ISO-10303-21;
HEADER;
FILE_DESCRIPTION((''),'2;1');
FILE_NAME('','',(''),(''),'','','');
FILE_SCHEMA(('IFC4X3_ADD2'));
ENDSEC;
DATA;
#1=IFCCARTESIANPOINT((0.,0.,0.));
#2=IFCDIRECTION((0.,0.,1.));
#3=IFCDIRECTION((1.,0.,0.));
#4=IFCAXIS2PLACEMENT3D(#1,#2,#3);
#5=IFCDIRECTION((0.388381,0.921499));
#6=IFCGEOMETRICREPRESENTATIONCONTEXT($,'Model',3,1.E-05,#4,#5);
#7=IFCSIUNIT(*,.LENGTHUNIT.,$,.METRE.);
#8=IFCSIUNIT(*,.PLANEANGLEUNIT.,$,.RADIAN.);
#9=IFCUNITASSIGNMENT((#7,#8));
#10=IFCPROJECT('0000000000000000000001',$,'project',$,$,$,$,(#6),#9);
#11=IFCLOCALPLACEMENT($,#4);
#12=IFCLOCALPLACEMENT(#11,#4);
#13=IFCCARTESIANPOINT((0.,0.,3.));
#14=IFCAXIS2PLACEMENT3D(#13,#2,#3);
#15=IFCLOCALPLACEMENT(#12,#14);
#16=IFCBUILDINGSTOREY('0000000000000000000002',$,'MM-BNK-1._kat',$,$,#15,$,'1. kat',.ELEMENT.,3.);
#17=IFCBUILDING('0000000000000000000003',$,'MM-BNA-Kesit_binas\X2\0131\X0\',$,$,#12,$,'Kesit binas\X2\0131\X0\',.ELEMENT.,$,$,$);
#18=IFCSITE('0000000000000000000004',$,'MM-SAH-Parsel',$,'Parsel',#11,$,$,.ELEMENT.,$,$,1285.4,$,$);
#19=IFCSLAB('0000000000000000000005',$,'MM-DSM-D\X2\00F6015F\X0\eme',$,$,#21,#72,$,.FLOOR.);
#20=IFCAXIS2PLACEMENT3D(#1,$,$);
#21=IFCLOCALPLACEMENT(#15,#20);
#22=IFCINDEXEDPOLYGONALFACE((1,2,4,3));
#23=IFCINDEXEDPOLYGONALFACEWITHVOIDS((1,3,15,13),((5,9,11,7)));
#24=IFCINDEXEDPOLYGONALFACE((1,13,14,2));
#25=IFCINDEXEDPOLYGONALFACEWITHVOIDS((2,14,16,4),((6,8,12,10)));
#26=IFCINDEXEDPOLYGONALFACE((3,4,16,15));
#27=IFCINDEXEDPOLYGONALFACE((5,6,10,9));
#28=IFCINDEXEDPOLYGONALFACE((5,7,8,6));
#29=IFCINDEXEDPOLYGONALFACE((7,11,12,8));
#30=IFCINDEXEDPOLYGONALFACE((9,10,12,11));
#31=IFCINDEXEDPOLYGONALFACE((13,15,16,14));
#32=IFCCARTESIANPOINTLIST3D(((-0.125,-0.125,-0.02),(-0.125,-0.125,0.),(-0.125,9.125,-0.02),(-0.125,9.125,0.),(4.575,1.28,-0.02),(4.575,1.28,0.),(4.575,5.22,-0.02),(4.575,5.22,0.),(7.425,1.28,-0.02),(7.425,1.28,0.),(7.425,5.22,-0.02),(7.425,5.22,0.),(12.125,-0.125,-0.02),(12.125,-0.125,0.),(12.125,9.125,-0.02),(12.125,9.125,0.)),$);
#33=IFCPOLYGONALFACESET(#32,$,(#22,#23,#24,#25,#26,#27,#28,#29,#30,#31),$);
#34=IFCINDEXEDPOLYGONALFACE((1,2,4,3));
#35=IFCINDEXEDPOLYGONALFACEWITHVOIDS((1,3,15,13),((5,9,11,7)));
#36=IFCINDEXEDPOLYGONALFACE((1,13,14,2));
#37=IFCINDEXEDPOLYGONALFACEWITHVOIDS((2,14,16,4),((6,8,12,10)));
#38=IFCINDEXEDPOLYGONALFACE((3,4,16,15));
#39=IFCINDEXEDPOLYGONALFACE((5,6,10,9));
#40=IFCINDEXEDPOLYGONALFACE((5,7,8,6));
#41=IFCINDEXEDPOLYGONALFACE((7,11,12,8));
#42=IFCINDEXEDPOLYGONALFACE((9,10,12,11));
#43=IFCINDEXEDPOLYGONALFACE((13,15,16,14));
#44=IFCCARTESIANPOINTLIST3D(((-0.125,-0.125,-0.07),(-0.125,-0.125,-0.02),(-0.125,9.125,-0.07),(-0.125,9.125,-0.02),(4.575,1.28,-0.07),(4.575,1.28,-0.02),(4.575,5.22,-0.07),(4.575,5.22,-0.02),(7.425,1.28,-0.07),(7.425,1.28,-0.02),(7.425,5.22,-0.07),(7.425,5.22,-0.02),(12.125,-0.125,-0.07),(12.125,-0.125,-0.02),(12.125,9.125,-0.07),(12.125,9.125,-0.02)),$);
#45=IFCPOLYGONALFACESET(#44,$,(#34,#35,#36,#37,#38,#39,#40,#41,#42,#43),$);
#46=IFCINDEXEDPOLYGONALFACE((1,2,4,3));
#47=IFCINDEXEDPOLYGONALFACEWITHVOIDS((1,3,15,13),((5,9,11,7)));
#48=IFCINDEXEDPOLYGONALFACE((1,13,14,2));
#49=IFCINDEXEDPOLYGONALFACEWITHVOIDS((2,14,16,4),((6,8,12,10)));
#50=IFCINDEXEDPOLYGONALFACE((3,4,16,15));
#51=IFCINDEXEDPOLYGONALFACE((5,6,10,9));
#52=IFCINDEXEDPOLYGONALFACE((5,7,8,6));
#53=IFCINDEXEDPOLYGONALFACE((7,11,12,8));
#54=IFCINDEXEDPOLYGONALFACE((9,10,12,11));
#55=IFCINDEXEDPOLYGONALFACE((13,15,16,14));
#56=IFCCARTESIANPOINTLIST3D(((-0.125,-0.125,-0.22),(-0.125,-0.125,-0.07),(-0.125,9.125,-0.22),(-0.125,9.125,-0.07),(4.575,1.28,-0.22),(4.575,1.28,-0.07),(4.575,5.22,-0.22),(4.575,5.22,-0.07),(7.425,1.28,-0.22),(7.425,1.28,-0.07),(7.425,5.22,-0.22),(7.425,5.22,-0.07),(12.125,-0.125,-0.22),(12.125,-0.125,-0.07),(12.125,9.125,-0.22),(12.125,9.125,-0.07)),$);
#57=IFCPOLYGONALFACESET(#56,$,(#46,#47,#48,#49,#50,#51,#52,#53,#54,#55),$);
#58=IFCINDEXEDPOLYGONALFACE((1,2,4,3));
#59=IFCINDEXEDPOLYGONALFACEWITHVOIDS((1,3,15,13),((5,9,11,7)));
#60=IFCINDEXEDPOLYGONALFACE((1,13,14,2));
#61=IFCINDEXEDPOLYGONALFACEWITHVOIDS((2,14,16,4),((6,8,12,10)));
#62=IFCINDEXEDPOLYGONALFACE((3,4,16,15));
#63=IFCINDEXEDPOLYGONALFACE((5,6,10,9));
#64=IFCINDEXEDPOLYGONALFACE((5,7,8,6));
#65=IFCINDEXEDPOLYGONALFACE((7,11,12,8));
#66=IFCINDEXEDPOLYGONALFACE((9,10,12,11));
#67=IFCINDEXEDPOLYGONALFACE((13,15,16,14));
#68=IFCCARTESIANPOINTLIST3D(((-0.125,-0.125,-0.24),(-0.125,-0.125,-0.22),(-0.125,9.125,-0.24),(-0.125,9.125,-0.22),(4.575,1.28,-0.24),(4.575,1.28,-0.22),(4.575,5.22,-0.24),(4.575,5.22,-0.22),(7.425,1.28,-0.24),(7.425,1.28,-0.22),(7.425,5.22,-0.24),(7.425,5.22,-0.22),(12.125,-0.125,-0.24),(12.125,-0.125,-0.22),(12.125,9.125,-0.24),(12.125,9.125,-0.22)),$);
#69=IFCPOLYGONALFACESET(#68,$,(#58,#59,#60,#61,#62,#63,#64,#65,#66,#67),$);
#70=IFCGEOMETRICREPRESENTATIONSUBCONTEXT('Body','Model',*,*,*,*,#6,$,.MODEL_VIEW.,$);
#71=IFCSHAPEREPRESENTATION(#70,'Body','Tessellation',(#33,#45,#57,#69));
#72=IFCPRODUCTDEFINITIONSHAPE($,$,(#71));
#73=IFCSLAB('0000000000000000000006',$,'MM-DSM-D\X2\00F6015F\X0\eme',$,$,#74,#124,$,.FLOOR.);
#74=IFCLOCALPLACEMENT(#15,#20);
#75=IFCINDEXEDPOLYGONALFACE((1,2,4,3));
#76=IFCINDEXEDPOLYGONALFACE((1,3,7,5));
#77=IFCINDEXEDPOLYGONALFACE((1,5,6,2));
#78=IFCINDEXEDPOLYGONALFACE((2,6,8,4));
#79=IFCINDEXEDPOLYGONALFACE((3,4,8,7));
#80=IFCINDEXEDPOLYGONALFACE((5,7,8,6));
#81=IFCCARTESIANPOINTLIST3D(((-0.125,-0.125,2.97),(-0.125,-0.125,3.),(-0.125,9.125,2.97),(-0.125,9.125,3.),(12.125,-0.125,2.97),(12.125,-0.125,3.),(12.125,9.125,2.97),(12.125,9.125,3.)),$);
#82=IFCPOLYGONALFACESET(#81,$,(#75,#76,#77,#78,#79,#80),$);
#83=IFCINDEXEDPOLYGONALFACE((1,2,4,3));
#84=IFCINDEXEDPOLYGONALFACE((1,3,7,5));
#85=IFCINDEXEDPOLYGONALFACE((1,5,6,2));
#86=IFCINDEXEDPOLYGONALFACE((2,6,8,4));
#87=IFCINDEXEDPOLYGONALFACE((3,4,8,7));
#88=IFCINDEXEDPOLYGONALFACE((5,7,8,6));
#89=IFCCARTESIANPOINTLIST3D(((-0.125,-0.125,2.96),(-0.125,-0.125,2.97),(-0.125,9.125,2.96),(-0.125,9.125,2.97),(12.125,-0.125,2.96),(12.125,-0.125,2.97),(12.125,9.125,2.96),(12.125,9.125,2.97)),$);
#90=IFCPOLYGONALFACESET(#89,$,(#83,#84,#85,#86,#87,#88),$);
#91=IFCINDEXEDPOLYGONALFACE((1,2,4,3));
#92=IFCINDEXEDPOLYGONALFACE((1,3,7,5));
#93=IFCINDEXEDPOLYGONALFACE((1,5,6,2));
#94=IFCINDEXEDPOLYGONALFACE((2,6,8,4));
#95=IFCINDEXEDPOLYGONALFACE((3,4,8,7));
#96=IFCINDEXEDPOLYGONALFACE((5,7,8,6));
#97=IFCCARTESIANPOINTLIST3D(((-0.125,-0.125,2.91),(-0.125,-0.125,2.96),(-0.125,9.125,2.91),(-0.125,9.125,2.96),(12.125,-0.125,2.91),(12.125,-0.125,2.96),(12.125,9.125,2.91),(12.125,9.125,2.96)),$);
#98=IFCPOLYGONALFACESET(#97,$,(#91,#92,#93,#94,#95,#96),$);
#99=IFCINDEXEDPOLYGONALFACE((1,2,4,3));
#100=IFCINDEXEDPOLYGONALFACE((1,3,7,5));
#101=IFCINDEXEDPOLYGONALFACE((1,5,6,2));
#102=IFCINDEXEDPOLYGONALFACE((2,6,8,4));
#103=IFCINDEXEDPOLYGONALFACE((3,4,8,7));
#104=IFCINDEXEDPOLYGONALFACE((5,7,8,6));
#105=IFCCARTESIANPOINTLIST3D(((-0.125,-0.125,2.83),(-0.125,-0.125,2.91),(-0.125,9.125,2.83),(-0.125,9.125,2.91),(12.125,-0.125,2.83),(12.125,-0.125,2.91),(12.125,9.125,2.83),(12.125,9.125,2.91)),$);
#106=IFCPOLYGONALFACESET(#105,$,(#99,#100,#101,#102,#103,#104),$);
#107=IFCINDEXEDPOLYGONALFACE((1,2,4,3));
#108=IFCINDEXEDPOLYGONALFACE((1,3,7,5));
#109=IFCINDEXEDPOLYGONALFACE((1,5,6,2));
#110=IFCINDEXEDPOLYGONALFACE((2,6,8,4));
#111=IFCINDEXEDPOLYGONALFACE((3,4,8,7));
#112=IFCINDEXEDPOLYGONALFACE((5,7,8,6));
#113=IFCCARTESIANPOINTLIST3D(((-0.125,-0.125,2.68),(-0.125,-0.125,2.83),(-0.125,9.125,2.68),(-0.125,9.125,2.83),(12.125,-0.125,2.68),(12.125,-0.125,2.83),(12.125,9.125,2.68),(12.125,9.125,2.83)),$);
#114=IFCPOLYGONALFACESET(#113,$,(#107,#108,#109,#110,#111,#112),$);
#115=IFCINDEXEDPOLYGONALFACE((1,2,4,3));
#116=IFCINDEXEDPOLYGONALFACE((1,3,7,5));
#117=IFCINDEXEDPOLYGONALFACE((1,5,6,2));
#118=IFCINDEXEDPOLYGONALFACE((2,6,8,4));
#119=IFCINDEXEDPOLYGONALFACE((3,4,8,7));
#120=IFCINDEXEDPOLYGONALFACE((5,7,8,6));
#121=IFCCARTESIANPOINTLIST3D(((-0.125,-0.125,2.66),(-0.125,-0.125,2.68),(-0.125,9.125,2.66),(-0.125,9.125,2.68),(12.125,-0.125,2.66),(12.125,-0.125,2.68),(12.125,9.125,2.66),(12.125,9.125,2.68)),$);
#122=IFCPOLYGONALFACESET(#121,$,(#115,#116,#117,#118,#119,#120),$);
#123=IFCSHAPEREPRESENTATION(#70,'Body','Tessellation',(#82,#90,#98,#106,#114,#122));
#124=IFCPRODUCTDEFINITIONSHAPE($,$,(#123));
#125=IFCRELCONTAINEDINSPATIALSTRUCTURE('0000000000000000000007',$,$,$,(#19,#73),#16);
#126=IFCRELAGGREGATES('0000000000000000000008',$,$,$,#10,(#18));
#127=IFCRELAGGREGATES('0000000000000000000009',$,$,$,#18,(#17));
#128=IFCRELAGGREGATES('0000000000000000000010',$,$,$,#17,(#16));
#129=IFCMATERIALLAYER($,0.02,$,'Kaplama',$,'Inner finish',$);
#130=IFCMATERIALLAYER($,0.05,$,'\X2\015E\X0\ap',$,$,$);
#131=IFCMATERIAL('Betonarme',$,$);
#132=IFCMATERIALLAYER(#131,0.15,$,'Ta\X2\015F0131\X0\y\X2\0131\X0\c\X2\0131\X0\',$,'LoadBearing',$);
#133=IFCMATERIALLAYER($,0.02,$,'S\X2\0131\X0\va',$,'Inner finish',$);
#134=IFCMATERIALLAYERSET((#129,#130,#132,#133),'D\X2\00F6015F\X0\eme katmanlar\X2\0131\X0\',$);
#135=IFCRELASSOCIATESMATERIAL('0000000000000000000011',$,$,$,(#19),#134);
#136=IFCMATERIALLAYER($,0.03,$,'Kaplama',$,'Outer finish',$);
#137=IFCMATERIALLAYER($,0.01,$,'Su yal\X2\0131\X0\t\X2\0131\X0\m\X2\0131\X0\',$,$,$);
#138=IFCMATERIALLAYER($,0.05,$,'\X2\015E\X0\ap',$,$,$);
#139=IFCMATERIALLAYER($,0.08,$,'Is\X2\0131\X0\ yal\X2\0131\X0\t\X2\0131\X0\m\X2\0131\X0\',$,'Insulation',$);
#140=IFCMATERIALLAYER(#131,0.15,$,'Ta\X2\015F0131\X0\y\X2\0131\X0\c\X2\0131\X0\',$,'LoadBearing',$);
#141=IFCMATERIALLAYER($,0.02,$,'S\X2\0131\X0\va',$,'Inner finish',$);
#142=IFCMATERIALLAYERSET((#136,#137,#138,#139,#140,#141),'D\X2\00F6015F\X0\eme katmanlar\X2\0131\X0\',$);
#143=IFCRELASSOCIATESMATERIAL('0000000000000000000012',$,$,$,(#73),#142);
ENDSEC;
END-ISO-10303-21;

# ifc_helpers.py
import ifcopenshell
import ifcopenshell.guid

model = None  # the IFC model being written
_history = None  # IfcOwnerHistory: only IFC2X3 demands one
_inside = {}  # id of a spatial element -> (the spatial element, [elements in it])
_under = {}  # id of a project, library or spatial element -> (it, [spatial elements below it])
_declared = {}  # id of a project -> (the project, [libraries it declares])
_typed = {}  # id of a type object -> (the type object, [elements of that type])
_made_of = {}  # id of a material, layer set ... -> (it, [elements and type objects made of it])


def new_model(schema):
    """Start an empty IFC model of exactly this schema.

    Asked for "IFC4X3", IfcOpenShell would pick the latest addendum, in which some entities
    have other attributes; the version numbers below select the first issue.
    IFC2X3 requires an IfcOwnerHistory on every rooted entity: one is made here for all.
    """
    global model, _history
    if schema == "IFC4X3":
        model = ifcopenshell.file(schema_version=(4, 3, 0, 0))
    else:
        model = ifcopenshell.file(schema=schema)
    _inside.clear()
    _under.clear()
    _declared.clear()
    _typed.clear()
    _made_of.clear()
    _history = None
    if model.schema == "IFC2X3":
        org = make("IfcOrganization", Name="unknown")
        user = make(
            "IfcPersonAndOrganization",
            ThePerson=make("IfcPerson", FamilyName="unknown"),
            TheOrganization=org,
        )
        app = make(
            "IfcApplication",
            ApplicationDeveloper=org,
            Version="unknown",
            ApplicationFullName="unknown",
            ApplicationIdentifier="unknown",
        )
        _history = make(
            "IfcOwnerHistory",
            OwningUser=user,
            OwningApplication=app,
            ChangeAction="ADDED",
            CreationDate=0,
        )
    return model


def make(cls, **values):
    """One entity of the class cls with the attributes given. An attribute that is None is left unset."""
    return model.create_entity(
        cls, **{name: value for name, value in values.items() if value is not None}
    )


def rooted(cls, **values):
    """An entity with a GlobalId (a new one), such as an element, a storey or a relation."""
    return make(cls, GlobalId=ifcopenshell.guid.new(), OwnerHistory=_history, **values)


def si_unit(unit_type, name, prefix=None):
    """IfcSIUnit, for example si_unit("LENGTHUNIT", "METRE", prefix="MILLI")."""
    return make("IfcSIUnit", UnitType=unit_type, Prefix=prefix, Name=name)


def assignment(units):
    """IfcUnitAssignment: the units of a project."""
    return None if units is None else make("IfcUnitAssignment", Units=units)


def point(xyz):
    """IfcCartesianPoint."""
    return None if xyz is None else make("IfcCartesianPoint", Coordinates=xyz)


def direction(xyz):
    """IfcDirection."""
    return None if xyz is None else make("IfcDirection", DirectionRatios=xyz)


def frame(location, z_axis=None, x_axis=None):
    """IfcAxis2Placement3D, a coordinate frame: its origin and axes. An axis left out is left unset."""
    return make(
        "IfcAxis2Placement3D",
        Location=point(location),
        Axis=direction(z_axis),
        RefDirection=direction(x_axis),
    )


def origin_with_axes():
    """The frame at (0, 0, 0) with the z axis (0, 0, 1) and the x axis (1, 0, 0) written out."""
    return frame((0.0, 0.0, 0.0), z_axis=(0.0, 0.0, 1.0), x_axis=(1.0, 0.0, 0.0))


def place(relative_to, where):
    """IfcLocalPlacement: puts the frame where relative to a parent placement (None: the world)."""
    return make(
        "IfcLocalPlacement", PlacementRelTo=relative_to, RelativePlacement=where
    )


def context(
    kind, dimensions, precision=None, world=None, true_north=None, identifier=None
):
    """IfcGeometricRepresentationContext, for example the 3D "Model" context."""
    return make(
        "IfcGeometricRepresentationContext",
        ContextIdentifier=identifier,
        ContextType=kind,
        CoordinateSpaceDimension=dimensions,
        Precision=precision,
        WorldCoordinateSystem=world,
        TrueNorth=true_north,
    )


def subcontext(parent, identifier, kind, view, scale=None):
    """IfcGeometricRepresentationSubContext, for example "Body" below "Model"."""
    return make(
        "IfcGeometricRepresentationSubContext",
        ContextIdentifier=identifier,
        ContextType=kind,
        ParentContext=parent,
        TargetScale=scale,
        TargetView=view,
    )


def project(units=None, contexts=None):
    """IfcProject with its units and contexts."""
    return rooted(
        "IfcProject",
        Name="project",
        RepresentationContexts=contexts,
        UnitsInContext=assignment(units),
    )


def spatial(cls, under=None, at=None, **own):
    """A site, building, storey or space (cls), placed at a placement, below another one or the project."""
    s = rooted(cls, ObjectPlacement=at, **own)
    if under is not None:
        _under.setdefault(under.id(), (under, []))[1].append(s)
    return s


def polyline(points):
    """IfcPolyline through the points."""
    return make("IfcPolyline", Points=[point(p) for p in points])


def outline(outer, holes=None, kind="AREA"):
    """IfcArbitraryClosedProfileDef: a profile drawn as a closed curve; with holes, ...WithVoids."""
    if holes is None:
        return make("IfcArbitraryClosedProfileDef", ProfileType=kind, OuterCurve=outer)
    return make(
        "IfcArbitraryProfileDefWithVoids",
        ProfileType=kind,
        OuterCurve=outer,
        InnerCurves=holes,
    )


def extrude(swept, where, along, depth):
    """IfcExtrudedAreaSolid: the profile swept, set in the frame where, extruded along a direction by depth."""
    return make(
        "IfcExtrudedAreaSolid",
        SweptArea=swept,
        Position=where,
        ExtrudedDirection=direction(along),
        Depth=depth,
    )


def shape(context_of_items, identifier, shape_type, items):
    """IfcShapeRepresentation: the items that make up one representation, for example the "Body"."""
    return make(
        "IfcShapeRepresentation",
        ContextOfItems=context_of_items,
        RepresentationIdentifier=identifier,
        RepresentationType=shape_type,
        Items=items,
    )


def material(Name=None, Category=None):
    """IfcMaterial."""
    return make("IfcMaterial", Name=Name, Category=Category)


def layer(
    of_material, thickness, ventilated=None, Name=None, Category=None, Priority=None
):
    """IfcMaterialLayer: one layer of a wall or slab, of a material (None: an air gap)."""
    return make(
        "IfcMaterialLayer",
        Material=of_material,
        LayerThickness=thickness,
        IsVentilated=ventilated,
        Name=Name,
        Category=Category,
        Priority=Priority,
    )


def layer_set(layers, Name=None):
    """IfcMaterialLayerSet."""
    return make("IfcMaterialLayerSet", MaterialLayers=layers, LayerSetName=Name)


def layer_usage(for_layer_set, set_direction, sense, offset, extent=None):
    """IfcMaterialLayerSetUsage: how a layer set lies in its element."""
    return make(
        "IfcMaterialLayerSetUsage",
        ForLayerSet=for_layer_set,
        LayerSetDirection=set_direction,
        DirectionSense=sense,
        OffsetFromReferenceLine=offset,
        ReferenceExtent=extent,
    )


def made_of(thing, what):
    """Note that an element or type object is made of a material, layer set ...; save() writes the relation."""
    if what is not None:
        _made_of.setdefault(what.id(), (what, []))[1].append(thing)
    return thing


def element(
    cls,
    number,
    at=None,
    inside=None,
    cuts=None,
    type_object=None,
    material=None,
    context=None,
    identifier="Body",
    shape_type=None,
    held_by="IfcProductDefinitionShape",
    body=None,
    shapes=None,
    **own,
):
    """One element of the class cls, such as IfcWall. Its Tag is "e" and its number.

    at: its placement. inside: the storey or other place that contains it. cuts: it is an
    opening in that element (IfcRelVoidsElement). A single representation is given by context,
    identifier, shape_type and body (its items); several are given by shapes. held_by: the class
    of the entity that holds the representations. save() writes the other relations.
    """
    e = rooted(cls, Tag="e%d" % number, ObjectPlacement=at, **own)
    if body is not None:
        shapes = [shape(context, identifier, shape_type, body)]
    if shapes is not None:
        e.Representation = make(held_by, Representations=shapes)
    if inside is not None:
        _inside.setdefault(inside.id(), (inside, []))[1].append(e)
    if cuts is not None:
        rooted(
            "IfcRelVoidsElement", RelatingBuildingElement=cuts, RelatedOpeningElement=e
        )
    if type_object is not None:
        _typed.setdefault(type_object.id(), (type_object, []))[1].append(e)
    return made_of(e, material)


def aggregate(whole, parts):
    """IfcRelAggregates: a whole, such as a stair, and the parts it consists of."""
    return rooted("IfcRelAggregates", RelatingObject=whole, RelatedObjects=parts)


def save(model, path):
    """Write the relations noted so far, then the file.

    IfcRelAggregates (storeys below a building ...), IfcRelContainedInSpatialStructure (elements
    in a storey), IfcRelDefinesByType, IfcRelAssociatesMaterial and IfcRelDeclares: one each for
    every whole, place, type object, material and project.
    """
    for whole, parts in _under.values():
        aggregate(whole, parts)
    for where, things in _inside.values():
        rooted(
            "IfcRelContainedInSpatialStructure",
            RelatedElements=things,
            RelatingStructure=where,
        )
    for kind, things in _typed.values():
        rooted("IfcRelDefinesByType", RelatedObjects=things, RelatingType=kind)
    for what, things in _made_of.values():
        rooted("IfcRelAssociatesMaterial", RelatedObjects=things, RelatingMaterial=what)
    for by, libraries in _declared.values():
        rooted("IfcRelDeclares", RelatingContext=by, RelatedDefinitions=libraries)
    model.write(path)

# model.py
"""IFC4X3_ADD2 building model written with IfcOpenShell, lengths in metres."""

from ifc_helpers import new_model, si_unit, direction, frame, origin_with_axes, place, context, subcontext, project, spatial, polyline, outline, extrude, material, layer, layer_set, layer_usage, element, save


model = new_model("IFC4X3_ADD2")

# Units and contexts
model_context = context("Model", 3, precision=1e-05, world=origin_with_axes(), true_north=direction((0.388381, 0.921499)))
body_context = subcontext(model_context, "Body", "Model", "MODEL_VIEW")
ifc_project = project(units=[si_unit("LENGTHUNIT", "METRE"), si_unit("PLANEANGLEUNIT", "RADIAN")], contexts=[model_context])

# Site, building, storey
site_placement = place(None, origin_with_axes())
site = spatial("IfcSite", under=ifc_project, at=site_placement, Name="MM-SAH-Parsel", ObjectType="Parsel", CompositionType="ELEMENT", RefElevation=1285.4)
building_placement = place(site_placement, origin_with_axes())
building = spatial("IfcBuilding", under=site, at=building_placement, Name="MM-BNA-Kesit_binası", LongName="Kesit binası", CompositionType="ELEMENT")
storey_placement = place(building_placement, frame((0.0, 0.0, 3.0), z_axis=(0.0, 0.0, 1.0), x_axis=(1.0, 0.0, 0.0)))
storey = spatial("IfcBuildingStorey", under=building, at=storey_placement, Name="MM-BNK-1._kat", LongName="1. kat", CompositionType="ELEMENT", Elevation=3.0)

# Shared definitions
ifc_material_1 = material(Name="Betonarme")

# Slab, opening
ifc_layer_1 = layer(None, 0.02, Name="Kaplama", Category="Inner finish")
ifc_layer_2 = layer(None, 0.05, Name="Şap")
ifc_layer_3 = layer(ifc_material_1, 0.15, Name="Taşıyıcı", Category="LoadBearing")
ifc_layer_4 = layer(None, 0.02, Name="Sıva", Category="Inner finish")
ifc_layer_set_1 = layer_set([ifc_layer_1, ifc_layer_2, ifc_layer_3, ifc_layer_4], Name="Döşeme katmanları")
ifc_layer_usage_1 = layer_usage(ifc_layer_set_1, "AXIS3", "NEGATIVE", 0.0)
slab_1_placement = place(storey_placement, origin_with_axes())
slab_1 = element("IfcSlab", 1, at=slab_1_placement, inside=storey, material=ifc_layer_usage_1, Name="MM-DSM-Döşeme", PredefinedType="FLOOR", context=body_context, shape_type="SweptSolid", body=[
    extrude(outline(polyline([(-0.125, -0.125), (12.125, -0.125), (12.125, 9.125), (-0.125, 9.125), (-0.125, -0.125)])), frame((0.0, 0.0, -0.02)), (0.0, 0.0, 1.0), 0.02),
    extrude(outline(polyline([(-0.125, -0.125), (12.125, -0.125), (12.125, 9.125), (-0.125, 9.125), (-0.125, -0.125)])), frame((0.0, 0.0, -0.07)), (0.0, 0.0, 1.0), 0.05),
    extrude(outline(polyline([(-0.125, -0.125), (12.125, -0.125), (12.125, 9.125), (-0.125, 9.125), (-0.125, -0.125)])), frame((0.0, 0.0, -0.22)), (0.0, 0.0, 1.0), 0.15),
    extrude(outline(polyline([(-0.125, -0.125), (12.125, -0.125), (12.125, 9.125), (-0.125, 9.125), (-0.125, -0.125)])), frame((0.0, 0.0, -0.24)), (0.0, 0.0, 1.0), 0.02),
])
opening_1_placement = place(storey_placement, origin_with_axes())
element("IfcOpeningElement", 2, at=opening_1_placement, cuts=slab_1, PredefinedType="OPENING", context=body_context, shape_type="SweptSolid", body=[
    extrude(outline(polyline([(4.575, 1.28), (4.575, 5.22), (7.425, 5.22), (7.425, 1.28), (4.575, 1.28)])), frame((0.0, 0.0, -0.24)), (0.0, 0.0, 1.0), 0.24),
])

# Slab
ifc_layer_5 = layer(None, 0.03, Name="Kaplama", Category="Outer finish")
ifc_layer_6 = layer(None, 0.01, Name="Su yalıtımı")
ifc_layer_7 = layer(None, 0.05, Name="Şap")
ifc_layer_8 = layer(None, 0.08, Name="Isı yalıtımı", Category="Insulation")
ifc_layer_9 = layer(ifc_material_1, 0.15, Name="Taşıyıcı", Category="LoadBearing")
ifc_layer_10 = layer(None, 0.02, Name="Sıva", Category="Inner finish")
ifc_layer_set_2 = layer_set([ifc_layer_5, ifc_layer_6, ifc_layer_7, ifc_layer_8, ifc_layer_9, ifc_layer_10], Name="Döşeme katmanları")
ifc_layer_usage_2 = layer_usage(ifc_layer_set_2, "AXIS3", "NEGATIVE", 3.0)
slab_2_placement = place(storey_placement, origin_with_axes())
element("IfcSlab", 3, at=slab_2_placement, inside=storey, material=ifc_layer_usage_2, Name="MM-DSM-Döşeme", PredefinedType="FLOOR", context=body_context, shape_type="SweptSolid", body=[
    extrude(outline(polyline([(-0.125, -0.125), (12.125, -0.125), (12.125, 9.125), (-0.125, 9.125), (-0.125, -0.125)])), frame((0.0, 0.0, 2.97)), (0.0, 0.0, 1.0), 0.03),
    extrude(outline(polyline([(-0.125, -0.125), (12.125, -0.125), (12.125, 9.125), (-0.125, 9.125), (-0.125, -0.125)])), frame((0.0, 0.0, 2.96)), (0.0, 0.0, 1.0), 0.01),
    extrude(outline(polyline([(-0.125, -0.125), (12.125, -0.125), (12.125, 9.125), (-0.125, 9.125), (-0.125, -0.125)])), frame((0.0, 0.0, 2.91)), (0.0, 0.0, 1.0), 0.05),
    extrude(outline(polyline([(-0.125, -0.125), (12.125, -0.125), (12.125, 9.125), (-0.125, 9.125), (-0.125, -0.125)])), frame((0.0, 0.0, 2.83)), (0.0, 0.0, 1.0), 0.08),
    extrude(outline(polyline([(-0.125, -0.125), (12.125, -0.125), (12.125, 9.125), (-0.125, 9.125), (-0.125, -0.125)])), frame((0.0, 0.0, 2.68)), (0.0, 0.0, 1.0), 0.15),
    extrude(outline(polyline([(-0.125, -0.125), (12.125, -0.125), (12.125, 9.125), (-0.125, 9.125), (-0.125, -0.125)])), frame((0.0, 0.0, 2.66)), (0.0, 0.0, 1.0), 0.02),
])

save(model, "model.ifc")
